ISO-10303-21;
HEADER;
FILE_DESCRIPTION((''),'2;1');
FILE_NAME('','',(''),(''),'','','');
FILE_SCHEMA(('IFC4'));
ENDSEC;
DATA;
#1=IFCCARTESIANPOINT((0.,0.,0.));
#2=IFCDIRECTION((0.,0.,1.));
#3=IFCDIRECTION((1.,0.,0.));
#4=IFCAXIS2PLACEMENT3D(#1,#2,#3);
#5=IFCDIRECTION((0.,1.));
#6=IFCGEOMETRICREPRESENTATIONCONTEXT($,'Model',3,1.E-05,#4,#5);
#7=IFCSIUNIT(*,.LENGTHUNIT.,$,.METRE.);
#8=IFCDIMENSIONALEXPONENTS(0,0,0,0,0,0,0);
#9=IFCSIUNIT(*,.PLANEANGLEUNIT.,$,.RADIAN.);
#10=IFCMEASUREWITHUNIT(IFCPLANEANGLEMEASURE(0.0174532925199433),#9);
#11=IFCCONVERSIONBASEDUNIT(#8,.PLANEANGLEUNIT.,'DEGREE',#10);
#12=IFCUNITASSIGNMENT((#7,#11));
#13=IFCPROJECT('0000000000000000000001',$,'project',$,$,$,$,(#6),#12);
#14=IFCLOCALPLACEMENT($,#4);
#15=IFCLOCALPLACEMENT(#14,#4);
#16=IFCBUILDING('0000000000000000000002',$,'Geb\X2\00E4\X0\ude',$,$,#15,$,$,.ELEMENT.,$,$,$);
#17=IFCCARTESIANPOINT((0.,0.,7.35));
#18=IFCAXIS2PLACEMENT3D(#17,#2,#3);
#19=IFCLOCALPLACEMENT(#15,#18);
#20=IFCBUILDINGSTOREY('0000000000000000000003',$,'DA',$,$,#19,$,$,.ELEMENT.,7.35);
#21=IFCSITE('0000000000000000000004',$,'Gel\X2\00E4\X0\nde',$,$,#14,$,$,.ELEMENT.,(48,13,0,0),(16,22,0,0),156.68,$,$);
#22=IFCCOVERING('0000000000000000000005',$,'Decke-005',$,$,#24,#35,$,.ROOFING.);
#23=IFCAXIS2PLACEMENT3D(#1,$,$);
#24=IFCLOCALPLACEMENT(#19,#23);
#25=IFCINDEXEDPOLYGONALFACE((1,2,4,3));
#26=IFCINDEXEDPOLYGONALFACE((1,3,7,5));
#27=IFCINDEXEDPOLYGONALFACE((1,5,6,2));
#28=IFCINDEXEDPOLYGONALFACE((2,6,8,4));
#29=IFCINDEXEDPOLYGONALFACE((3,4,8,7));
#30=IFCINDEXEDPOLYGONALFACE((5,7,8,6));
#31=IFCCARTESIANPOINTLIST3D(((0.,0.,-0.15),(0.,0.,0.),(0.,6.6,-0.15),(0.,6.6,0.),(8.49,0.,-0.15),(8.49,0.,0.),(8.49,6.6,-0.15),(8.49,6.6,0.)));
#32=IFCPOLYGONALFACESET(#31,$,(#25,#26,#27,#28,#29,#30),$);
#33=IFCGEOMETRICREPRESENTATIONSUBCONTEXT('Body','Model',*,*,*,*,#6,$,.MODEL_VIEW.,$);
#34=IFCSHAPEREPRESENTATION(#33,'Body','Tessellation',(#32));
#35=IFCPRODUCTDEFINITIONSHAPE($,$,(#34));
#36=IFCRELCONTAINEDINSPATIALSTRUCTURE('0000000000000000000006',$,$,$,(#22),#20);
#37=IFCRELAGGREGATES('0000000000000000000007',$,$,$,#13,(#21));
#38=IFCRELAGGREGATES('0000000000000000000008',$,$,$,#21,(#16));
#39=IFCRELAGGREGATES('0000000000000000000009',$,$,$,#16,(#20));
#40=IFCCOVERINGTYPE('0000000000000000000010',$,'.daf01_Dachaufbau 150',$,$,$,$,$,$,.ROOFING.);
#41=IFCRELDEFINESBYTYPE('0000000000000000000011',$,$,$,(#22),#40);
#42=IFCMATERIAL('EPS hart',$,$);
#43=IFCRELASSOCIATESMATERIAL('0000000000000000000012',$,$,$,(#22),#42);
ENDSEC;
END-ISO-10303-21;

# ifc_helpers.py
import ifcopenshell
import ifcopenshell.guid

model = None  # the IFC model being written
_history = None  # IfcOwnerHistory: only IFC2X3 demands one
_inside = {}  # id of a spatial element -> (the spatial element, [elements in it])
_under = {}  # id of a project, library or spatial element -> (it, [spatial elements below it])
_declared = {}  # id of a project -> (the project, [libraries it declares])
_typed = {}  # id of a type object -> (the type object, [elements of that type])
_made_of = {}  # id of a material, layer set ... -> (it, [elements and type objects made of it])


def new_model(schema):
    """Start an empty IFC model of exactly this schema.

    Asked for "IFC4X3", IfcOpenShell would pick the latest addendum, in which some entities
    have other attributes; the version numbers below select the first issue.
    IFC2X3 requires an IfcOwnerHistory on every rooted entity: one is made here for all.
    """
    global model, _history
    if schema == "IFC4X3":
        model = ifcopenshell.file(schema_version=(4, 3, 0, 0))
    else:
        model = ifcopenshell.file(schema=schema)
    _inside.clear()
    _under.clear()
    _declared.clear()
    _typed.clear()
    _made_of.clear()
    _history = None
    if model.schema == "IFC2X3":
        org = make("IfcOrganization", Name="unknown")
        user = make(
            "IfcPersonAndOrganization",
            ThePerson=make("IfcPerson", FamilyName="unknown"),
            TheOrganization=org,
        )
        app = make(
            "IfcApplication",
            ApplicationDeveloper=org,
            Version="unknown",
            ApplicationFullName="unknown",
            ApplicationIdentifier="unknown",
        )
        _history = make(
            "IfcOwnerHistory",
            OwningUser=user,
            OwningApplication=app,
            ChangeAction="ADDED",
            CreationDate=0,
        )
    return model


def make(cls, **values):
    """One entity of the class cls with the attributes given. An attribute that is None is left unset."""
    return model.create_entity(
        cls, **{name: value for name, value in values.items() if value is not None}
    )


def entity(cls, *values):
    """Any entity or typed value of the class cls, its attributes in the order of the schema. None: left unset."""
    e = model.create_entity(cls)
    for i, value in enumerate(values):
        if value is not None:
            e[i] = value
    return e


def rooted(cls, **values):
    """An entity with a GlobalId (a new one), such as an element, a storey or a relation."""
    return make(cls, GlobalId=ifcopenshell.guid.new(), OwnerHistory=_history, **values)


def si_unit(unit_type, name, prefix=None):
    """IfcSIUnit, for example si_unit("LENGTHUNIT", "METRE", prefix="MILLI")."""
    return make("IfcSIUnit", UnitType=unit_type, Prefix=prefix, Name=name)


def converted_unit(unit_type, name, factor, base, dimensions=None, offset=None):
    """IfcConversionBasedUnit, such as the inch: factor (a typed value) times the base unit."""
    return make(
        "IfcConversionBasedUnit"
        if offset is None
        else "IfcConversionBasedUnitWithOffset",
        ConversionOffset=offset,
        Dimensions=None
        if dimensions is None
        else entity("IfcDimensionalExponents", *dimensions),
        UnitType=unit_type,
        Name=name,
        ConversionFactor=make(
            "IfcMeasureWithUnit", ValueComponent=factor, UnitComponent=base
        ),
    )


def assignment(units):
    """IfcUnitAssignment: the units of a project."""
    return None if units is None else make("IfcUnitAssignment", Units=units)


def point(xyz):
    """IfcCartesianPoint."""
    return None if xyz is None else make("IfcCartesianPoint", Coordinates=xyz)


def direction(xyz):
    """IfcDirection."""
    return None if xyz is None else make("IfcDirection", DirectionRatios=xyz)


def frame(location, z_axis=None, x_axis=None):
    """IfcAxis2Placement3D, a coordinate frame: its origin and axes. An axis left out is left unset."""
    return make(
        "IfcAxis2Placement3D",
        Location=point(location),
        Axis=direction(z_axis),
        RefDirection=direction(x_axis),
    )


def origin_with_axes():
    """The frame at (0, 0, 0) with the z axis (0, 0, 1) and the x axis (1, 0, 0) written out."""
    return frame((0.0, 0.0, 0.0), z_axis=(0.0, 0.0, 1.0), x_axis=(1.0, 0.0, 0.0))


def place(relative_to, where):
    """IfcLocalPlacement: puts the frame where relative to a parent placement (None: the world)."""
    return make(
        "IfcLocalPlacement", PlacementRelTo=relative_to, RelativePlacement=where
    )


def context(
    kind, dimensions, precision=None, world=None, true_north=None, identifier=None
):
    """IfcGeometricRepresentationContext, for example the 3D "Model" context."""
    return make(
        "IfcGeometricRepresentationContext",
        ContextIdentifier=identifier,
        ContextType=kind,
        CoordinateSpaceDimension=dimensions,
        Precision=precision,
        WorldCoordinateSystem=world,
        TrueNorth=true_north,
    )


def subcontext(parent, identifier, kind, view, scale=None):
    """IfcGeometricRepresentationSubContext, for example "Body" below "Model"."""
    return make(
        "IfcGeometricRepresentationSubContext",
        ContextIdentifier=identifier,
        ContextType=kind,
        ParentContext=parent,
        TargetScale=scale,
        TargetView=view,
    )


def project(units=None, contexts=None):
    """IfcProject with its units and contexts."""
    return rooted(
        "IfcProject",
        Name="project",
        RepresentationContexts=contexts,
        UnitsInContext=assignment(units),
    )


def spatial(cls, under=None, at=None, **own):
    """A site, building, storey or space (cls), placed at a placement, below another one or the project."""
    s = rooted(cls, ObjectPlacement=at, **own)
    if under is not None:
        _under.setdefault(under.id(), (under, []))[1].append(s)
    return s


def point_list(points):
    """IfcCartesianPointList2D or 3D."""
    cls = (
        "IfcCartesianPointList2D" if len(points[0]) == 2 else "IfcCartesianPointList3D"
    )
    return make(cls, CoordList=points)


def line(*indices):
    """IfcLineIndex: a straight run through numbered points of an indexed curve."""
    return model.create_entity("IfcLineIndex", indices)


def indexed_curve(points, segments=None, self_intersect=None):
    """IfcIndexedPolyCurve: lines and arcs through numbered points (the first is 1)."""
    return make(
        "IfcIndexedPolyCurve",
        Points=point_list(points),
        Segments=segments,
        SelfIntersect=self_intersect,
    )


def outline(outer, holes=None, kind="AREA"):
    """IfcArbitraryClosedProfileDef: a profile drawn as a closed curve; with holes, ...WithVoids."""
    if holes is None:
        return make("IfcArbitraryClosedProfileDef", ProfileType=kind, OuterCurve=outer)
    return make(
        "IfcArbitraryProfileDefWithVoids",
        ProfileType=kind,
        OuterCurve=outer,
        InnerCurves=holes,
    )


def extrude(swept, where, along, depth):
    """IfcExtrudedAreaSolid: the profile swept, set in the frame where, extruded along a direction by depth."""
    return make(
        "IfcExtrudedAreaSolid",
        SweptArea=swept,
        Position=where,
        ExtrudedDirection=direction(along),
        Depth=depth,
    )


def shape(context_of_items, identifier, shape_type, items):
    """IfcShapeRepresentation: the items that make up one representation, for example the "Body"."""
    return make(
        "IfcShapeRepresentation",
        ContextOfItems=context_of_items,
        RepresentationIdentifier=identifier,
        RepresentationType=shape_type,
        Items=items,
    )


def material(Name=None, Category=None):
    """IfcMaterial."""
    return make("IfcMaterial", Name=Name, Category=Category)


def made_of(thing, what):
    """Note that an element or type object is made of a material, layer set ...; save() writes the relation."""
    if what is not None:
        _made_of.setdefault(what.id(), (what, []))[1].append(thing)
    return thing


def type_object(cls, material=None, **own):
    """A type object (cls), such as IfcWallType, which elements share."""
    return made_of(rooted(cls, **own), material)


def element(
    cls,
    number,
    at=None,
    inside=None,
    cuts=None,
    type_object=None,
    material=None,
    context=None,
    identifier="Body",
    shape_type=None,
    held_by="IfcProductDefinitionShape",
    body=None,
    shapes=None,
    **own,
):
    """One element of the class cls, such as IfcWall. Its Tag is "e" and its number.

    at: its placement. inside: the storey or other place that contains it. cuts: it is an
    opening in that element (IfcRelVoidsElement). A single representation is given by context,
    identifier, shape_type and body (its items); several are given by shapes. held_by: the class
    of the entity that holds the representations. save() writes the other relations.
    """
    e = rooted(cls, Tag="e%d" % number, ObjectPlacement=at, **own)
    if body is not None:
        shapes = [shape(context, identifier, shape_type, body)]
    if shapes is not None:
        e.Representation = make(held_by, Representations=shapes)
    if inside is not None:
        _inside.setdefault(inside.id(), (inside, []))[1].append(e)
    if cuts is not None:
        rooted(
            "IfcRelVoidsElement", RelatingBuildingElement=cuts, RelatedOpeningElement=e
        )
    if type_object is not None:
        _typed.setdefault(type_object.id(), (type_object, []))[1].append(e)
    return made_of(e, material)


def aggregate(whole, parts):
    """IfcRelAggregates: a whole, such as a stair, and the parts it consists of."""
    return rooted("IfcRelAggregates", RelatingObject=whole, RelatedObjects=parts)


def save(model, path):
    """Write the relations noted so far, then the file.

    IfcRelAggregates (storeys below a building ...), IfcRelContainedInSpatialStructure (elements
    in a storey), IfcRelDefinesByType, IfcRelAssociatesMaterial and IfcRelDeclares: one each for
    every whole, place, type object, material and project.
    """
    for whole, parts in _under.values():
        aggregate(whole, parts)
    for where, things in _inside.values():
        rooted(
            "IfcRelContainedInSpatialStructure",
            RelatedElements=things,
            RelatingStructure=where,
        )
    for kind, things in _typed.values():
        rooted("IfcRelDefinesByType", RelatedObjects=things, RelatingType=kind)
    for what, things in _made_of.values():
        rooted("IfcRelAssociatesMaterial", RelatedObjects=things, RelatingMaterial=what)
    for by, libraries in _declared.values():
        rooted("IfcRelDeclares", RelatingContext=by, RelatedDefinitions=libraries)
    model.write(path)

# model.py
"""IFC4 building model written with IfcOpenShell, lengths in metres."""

from ifc_helpers import new_model, entity, si_unit, converted_unit, direction, frame, origin_with_axes, place, context, subcontext, project, spatial, line, indexed_curve, outline, extrude, material, type_object, element, save


model = new_model("IFC4")

# Units and contexts
model_context = context("Model", 3, precision=1e-05, world=origin_with_axes(), true_north=direction((0.0, 1.0)))
body_context = subcontext(model_context, "Body", "Model", "MODEL_VIEW")
ifc_project = project(units=[si_unit("LENGTHUNIT", "METRE"), converted_unit("PLANEANGLEUNIT", "DEGREE", entity("IfcPlaneAngleMeasure", 0.0174532925199433), si_unit("PLANEANGLEUNIT", "RADIAN"), dimensions=[0, 0, 0, 0, 0, 0, 0])], contexts=[model_context])

# Site, building, storey
site_placement = place(None, origin_with_axes())
site = spatial("IfcSite", under=ifc_project, at=site_placement, Name="Gelände", CompositionType="ELEMENT", RefLatitude=(48, 13, 0, 0), RefLongitude=(16, 22, 0, 0), RefElevation=156.68)
building_placement = place(site_placement, origin_with_axes())
building = spatial("IfcBuilding", under=site, at=building_placement, Name="Gebäude", CompositionType="ELEMENT")
storey_placement = place(building_placement, frame((0.0, 0.0, 7.35), z_axis=(0.0, 0.0, 1.0), x_axis=(1.0, 0.0, 0.0)))
storey = spatial("IfcBuildingStorey", under=building, at=storey_placement, Name="DA", CompositionType="ELEMENT", Elevation=7.35)

# Covering
ifc_material = material(Name="EPS hart")
covering_type = type_object("IfcCoveringType", Name=".daf01_Dachaufbau 150", PredefinedType="ROOFING")
covering_placement = place(storey_placement, origin_with_axes())
element("IfcCovering", 1, at=covering_placement, inside=storey, type_object=covering_type, material=ifc_material, Name="Decke-005", PredefinedType="ROOFING", context=body_context, shape_type="SweptSolid", body=[
    extrude(outline(indexed_curve([(0.0, 0.0), (8.49, 0.0), (8.49, 6.6), (0.0, 6.6)], segments=[line(1, 2, 3, 4, 1)])), frame((0.0, 0.0, -0.15), z_axis=(0.0, 0.0, 1.0), x_axis=(1.0, 0.0, 0.0)), (0.0, 0.0, 1.0), 0.15),
])

save(model, "model.ifc")
